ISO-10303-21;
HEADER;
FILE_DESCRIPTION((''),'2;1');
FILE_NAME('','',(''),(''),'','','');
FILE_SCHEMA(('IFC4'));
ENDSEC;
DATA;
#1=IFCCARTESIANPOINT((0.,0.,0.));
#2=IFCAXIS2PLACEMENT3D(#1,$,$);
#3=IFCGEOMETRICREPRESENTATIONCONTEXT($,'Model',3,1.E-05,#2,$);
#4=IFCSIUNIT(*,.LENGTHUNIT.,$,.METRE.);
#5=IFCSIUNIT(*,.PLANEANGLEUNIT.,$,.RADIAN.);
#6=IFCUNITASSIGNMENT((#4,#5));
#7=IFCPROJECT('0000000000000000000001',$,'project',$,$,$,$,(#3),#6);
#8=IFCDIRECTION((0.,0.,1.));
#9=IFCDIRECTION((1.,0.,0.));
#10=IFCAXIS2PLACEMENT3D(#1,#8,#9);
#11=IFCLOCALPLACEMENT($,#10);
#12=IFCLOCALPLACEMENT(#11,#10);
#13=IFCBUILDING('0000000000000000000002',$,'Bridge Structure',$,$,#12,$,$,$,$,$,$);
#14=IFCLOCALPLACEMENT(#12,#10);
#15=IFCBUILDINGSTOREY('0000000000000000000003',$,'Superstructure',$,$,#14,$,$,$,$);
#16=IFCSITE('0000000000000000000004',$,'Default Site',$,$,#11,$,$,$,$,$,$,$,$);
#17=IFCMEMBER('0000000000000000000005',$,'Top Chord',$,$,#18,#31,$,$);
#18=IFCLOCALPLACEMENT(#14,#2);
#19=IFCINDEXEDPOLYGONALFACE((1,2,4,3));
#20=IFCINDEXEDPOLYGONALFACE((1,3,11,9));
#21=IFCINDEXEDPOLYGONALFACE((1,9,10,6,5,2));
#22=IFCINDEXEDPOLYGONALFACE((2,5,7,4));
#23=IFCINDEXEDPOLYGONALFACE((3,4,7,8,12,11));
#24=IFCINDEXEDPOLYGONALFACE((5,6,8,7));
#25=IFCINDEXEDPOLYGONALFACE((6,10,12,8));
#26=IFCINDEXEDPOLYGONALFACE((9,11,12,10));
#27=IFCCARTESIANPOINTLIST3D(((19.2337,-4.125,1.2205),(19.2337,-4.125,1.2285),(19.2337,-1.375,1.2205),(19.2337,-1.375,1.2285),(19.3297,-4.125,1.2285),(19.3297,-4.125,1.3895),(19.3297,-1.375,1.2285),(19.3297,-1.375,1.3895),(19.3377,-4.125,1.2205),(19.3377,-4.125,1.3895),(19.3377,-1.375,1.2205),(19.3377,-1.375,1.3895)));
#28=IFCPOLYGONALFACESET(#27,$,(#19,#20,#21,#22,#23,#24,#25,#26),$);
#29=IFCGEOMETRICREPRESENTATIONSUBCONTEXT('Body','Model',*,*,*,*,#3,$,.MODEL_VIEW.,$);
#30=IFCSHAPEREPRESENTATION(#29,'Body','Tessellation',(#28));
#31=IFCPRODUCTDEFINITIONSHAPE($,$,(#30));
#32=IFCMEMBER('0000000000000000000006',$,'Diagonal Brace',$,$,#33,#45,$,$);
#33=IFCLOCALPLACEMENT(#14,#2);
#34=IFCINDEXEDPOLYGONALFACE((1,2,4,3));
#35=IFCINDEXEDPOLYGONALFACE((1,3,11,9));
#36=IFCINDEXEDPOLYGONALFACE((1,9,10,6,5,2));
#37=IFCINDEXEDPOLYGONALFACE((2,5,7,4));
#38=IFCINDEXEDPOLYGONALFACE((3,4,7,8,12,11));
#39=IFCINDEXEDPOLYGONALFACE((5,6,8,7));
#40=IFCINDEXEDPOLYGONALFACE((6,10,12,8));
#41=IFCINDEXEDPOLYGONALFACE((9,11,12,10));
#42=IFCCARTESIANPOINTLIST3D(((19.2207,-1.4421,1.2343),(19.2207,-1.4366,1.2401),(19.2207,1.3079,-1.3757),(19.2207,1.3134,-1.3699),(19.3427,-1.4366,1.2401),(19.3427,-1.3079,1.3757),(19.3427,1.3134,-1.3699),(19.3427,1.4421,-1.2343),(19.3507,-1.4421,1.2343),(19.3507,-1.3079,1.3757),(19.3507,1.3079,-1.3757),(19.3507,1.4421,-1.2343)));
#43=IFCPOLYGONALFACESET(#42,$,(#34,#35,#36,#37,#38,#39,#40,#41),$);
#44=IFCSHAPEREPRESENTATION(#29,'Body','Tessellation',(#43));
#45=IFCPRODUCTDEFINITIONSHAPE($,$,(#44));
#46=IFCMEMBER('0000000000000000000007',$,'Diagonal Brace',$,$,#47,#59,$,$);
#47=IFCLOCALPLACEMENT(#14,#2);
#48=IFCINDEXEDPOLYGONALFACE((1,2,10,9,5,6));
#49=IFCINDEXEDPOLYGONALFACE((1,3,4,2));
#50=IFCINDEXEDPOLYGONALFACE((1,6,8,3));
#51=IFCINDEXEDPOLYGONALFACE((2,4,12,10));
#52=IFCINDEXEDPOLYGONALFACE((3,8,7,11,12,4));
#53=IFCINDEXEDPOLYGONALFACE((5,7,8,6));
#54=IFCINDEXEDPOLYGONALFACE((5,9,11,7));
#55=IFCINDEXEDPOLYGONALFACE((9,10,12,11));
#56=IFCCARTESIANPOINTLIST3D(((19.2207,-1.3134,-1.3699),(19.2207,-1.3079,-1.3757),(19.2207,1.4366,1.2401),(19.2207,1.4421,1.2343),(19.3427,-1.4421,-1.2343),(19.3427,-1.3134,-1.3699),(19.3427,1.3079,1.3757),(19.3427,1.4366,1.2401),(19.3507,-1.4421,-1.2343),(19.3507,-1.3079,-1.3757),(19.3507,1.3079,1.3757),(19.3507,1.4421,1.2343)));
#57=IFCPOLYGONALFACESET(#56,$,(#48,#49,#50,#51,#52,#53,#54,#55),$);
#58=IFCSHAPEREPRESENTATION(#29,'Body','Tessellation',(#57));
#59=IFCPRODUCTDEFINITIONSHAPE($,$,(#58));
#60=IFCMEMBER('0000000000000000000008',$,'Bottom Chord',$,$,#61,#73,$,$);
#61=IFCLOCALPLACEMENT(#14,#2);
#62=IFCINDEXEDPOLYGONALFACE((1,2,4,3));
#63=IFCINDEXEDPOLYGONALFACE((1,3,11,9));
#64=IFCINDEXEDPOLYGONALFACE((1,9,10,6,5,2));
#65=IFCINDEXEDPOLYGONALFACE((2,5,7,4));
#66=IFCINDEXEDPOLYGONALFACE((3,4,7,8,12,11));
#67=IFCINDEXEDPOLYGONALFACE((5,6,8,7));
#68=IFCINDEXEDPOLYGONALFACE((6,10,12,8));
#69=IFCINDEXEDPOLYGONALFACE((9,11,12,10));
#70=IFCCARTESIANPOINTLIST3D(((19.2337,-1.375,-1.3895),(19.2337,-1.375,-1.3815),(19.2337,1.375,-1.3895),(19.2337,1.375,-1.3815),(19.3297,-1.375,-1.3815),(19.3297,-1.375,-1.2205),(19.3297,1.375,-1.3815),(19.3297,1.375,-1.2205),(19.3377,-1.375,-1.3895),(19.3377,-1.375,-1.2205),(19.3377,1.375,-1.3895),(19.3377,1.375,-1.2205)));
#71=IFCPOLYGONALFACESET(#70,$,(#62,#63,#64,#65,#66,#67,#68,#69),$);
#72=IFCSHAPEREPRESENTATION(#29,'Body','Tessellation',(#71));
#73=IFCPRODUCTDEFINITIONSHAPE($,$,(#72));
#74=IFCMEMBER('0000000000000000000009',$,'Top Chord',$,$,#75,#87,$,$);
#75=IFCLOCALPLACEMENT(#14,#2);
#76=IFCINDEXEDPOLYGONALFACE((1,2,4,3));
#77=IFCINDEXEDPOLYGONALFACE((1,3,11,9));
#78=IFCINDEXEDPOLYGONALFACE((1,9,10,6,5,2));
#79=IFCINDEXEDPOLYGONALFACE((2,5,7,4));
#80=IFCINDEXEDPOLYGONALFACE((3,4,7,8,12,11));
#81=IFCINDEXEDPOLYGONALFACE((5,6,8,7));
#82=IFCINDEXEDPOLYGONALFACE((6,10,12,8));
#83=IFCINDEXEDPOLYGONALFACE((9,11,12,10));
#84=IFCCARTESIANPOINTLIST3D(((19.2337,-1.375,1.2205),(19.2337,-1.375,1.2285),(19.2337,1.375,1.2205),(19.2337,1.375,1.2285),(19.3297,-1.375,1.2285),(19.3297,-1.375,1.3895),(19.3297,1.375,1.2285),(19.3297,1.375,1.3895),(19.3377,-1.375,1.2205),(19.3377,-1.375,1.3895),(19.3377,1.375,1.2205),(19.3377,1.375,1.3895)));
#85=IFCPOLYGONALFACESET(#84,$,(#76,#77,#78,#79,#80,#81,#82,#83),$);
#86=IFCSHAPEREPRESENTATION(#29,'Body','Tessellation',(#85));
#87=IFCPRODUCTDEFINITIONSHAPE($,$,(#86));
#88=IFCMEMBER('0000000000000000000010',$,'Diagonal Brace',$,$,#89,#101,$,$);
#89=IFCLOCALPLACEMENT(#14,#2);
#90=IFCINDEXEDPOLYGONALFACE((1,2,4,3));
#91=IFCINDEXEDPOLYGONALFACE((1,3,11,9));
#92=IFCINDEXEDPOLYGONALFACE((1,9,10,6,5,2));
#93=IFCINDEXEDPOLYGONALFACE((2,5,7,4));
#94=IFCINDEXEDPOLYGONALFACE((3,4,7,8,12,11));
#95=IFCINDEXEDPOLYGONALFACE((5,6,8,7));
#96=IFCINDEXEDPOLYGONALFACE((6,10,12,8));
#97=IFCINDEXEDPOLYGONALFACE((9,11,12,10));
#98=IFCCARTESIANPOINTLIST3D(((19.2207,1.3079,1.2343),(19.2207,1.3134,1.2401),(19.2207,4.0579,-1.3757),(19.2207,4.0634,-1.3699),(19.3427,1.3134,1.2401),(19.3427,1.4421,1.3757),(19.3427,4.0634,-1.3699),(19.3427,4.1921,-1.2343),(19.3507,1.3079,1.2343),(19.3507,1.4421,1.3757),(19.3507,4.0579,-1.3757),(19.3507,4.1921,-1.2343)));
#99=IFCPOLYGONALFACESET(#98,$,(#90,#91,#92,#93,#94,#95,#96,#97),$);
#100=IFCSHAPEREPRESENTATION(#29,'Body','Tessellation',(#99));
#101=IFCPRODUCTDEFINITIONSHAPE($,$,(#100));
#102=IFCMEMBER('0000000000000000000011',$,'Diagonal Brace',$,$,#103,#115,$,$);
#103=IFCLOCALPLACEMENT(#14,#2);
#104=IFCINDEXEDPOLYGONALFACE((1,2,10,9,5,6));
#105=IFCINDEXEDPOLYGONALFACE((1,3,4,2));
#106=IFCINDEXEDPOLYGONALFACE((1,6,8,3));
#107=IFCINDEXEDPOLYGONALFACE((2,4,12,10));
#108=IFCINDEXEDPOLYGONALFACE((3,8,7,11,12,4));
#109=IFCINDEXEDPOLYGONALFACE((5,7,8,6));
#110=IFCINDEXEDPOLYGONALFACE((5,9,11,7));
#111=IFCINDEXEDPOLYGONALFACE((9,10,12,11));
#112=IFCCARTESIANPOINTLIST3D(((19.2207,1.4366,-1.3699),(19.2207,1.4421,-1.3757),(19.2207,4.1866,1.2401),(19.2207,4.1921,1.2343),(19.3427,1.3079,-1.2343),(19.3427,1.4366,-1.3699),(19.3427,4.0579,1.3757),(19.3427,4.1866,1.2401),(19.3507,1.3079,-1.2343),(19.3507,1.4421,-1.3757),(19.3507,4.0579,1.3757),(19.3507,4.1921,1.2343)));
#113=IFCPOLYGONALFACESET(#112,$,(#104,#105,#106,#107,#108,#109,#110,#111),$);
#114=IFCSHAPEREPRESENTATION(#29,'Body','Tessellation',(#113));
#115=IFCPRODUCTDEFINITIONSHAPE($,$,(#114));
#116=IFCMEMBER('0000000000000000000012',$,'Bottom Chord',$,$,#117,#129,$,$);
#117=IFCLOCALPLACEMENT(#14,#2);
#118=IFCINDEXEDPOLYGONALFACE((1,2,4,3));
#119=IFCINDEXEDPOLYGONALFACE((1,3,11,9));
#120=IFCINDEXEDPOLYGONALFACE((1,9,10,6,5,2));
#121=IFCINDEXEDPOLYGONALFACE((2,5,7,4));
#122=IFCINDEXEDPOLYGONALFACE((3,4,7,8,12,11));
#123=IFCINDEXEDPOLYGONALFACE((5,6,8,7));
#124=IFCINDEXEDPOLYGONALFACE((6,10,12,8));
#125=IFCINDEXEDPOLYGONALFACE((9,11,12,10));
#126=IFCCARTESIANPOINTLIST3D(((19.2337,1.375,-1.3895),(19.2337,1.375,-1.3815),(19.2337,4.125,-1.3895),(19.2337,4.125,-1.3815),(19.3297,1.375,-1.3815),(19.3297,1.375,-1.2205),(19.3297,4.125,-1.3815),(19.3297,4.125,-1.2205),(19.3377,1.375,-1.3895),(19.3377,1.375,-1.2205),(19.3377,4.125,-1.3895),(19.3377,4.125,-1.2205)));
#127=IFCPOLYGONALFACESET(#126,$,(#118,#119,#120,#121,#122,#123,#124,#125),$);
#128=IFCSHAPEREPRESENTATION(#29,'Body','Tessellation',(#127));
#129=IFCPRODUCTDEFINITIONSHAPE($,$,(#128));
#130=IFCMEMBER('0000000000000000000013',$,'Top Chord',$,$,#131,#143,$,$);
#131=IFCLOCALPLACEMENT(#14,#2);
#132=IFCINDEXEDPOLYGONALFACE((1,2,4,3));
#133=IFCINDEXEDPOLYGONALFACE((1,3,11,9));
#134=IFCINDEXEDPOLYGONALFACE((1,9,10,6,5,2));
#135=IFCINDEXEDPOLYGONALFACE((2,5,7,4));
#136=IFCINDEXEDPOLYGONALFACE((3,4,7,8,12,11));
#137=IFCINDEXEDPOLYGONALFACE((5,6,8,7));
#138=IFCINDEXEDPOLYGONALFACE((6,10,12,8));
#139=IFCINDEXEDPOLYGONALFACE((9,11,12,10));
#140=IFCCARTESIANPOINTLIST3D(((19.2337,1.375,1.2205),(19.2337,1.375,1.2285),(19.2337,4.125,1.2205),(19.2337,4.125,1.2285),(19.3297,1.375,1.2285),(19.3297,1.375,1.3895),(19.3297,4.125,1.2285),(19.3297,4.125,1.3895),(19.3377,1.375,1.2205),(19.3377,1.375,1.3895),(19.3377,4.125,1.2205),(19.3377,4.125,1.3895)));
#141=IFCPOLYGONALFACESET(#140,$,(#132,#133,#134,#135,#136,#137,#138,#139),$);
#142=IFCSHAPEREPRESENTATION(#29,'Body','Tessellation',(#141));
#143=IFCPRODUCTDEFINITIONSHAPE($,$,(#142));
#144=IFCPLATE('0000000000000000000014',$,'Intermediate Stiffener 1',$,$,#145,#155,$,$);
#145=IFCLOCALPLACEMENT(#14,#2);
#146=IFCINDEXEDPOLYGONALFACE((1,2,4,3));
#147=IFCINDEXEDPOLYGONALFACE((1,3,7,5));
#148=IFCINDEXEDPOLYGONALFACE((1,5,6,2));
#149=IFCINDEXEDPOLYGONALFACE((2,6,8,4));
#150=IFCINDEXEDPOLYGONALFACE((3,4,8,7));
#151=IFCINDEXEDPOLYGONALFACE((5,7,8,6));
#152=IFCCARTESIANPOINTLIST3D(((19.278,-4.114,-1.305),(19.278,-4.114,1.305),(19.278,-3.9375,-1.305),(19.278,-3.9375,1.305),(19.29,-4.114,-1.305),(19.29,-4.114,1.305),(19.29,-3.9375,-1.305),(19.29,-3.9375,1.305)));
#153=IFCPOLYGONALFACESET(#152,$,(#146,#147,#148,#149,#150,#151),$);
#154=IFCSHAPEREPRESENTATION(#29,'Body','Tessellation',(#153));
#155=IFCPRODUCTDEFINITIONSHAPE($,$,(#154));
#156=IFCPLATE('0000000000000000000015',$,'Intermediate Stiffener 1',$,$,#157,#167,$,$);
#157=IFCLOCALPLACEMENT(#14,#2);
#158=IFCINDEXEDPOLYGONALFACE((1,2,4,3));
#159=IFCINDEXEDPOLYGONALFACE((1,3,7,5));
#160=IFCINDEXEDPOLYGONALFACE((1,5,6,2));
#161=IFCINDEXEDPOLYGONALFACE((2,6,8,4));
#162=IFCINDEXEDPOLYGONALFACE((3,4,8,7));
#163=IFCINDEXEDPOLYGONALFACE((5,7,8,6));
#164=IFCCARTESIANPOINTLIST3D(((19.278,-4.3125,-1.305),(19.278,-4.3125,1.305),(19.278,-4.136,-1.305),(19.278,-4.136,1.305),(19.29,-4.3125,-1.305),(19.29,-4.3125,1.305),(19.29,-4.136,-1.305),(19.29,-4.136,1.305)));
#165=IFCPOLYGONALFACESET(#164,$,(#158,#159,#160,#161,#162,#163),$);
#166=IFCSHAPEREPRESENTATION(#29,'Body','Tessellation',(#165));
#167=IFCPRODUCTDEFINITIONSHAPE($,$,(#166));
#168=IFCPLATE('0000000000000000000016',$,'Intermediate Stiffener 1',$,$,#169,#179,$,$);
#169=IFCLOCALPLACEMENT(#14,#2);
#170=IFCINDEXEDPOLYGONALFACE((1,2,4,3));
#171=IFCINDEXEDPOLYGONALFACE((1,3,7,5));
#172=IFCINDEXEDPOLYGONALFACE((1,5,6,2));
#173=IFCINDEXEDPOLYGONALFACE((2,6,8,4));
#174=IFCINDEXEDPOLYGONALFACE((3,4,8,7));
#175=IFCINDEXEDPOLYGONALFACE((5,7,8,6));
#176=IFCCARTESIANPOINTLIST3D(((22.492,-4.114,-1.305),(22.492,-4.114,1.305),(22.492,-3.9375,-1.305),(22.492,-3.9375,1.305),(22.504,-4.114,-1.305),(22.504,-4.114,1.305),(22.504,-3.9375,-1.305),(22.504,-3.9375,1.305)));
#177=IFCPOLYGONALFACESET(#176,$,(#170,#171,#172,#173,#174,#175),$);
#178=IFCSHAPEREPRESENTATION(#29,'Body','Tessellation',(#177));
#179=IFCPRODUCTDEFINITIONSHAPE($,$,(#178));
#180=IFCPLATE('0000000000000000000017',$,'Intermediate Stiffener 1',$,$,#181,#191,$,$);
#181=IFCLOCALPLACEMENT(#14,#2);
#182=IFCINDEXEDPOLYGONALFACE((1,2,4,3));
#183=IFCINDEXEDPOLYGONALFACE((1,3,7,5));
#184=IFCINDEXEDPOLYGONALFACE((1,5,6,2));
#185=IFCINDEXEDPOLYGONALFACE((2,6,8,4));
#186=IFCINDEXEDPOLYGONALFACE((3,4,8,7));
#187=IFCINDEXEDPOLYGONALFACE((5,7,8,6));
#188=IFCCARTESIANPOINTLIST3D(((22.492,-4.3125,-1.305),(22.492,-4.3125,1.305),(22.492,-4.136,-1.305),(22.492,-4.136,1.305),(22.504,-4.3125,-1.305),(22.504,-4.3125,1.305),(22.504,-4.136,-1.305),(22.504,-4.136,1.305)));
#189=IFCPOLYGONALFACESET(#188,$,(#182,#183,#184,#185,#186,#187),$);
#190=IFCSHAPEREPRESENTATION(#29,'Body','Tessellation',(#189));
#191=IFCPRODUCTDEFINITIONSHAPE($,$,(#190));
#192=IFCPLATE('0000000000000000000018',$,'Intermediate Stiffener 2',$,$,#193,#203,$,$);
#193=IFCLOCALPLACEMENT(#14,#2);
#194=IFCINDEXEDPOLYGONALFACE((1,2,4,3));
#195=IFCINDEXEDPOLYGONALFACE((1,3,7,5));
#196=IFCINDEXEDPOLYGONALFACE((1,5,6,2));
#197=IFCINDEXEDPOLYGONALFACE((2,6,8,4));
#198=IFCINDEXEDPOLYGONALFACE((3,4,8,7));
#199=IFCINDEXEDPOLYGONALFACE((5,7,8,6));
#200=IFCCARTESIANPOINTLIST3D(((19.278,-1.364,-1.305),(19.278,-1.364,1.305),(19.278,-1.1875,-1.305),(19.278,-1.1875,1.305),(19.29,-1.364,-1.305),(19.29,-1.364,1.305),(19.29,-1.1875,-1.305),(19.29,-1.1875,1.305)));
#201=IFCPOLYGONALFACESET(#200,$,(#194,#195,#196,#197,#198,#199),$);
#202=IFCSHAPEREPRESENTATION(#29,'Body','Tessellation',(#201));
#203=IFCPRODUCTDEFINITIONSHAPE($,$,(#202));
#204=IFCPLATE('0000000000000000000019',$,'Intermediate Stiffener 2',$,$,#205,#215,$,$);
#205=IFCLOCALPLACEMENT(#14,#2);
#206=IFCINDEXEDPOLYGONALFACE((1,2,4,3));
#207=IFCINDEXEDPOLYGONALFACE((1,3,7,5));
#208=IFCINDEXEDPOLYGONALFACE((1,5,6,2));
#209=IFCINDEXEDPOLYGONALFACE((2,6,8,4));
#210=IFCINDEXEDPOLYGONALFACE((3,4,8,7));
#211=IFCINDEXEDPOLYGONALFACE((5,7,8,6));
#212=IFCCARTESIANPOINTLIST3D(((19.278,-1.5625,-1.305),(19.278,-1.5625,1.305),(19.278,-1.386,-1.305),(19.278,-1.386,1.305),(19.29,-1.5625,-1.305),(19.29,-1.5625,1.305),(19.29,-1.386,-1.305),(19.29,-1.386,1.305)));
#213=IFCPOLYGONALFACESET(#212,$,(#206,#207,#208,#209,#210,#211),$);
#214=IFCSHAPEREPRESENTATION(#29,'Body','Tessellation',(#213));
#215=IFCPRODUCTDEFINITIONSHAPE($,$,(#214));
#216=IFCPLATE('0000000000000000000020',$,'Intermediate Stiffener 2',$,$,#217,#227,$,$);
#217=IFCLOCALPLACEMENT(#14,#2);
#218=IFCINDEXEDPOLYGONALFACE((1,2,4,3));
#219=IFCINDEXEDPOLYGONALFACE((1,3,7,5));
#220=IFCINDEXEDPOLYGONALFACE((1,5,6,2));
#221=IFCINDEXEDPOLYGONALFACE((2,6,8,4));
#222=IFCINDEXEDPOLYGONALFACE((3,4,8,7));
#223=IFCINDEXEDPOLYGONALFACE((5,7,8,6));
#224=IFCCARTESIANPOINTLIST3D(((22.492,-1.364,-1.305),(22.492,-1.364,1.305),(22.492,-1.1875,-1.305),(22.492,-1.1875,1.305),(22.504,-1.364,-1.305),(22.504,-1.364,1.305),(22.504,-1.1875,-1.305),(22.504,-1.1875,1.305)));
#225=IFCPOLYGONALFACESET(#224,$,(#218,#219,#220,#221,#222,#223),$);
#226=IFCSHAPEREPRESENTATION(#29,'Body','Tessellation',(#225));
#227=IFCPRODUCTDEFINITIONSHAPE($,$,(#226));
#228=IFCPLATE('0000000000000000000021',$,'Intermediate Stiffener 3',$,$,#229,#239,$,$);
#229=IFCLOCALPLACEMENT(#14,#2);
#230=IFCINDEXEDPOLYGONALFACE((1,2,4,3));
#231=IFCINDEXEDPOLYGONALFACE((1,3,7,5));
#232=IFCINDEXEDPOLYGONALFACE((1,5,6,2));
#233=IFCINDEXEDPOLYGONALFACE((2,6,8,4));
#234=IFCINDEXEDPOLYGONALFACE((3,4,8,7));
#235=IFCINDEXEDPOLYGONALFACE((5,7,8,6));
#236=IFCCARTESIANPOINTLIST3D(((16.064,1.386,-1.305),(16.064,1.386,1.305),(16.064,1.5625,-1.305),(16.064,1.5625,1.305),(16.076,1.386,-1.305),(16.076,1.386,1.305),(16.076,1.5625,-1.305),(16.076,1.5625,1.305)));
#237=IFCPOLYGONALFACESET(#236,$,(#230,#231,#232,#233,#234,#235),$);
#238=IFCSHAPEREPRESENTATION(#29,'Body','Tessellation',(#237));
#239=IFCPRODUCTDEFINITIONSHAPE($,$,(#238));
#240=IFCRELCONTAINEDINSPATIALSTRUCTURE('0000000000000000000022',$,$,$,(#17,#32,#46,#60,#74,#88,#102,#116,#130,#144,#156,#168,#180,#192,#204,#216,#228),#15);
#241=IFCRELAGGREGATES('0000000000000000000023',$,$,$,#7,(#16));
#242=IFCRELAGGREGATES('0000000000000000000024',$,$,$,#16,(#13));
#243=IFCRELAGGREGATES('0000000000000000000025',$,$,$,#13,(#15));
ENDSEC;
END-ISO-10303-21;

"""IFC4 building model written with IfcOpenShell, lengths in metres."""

from ifc_helpers import new_model, si_unit, frame, origin, origin_with_axes, origin_2d_with_axis, place, context, subcontext, project, spatial, rectangle, l_section, extrude, element, save


model = new_model("IFC4")

# Units and contexts
model_context = context("Model", 3, precision=1e-05, world=origin())
body_context = subcontext(model_context, "Body", "Model", "MODEL_VIEW")
ifc_project = project(units=[si_unit("LENGTHUNIT", "METRE"), si_unit("PLANEANGLEUNIT", "RADIAN")], contexts=[model_context])

# Site, building, storey
site_placement = place(None, origin_with_axes())
site = spatial("IfcSite", under=ifc_project, at=site_placement, Name="Default Site")
building_placement = place(site_placement, origin_with_axes())
building = spatial("IfcBuilding", under=site, at=building_placement, Name="Bridge Structure")
storey_placement = place(building_placement, origin_with_axes())
storey = spatial("IfcBuildingStorey", under=building, at=storey_placement, Name="Superstructure")

# Members
for number, where, z_axis, x_axis, name in (
    (1, (19.2857, -4.125, 1.305), (0.0, 1.0, 0.0), (-1.0, 0.0, 0.0), "Top Chord"),
):
    element("IfcMember", number, at=place(storey_placement, frame(where, z_axis=z_axis, x_axis=x_axis)), inside=storey, Name=name, context=body_context, shape_type="SweptSolid", body=[
        extrude(l_section(Depth=0.169, Width=0.104, Thickness=0.008, at=origin_2d_with_axis()), origin_with_axes(), (0.0, 0.0, 1.0), 2.75),
    ])
for number, where, z_axis, x_axis, name in (
    (2, (19.2857, -1.375, 1.305), (0.0, 0.725329, -0.688403), (-1.0, 0.0, 0.0), "Diagonal Brace"),
    (3, (19.2857, -1.375, -1.305), (0.0, 0.725329, 0.688403), (-1.0, 0.0, 0.0), "Diagonal Brace"),
):
    element("IfcMember", number, at=place(storey_placement, frame(where, z_axis=z_axis, x_axis=x_axis)), inside=storey, Name=name, context=body_context, shape_type="SweptSolid", body=[
        extrude(l_section(Depth=0.195, Width=0.13, Thickness=0.008, at=origin_2d_with_axis()), origin_with_axes(), (0.0, 0.0, 1.0), 3.7914),
    ])
for number, where, z_axis, x_axis, name in (
    (4, (19.2857, -1.375, -1.305), (0.0, 1.0, 0.0), (-1.0, 0.0, 0.0), "Bottom Chord"),
    (5, (19.2857, -1.375, 1.305), (0.0, 1.0, 0.0), (-1.0, 0.0, 0.0), "Top Chord"),
):
    element("IfcMember", number, at=place(storey_placement, frame(where, z_axis=z_axis, x_axis=x_axis)), inside=storey, Name=name, context=body_context, shape_type="SweptSolid", body=[
        extrude(l_section(Depth=0.169, Width=0.104, Thickness=0.008, at=origin_2d_with_axis()), origin_with_axes(), (0.0, 0.0, 1.0), 2.75),
    ])
for number, where, z_axis, x_axis, name in (
    (6, (19.2857, 1.375, 1.305), (0.0, 0.725329, -0.688403), (-1.0, 0.0, 0.0), "Diagonal Brace"),
    (7, (19.2857, 1.375, -1.305), (0.0, 0.725329, 0.688403), (-1.0, 0.0, 0.0), "Diagonal Brace"),
):
    element("IfcMember", number, at=place(storey_placement, frame(where, z_axis=z_axis, x_axis=x_axis)), inside=storey, Name=name, context=body_context, shape_type="SweptSolid", body=[
        extrude(l_section(Depth=0.195, Width=0.13, Thickness=0.008, at=origin_2d_with_axis()), origin_with_axes(), (0.0, 0.0, 1.0), 3.7914),
    ])
for number, where, z_axis, x_axis, name in (
    (8, (19.2857, 1.375, -1.305), (0.0, 1.0, 0.0), (-1.0, 0.0, 0.0), "Bottom Chord"),
    (9, (19.2857, 1.375, 1.305), (0.0, 1.0, 0.0), (-1.0, 0.0, 0.0), "Top Chord"),
):
    element("IfcMember", number, at=place(storey_placement, frame(where, z_axis=z_axis, x_axis=x_axis)), inside=storey, Name=name, context=body_context, shape_type="SweptSolid", body=[
        extrude(l_section(Depth=0.169, Width=0.104, Thickness=0.008, at=origin_2d_with_axis()), origin_with_axes(), (0.0, 0.0, 1.0), 2.75),
    ])

# Plates
for number, where, z_axis, x_axis, name in (
    (10, (19.284, -4.0258, -1.305), (0.0, 0.0, 1.0), (1.0, 0.0, 0.0), "Intermediate Stiffener 1"),
    (11, (19.284, -4.2243, -1.305), (0.0, 0.0, 1.0), (1.0, 0.0, 0.0), "Intermediate Stiffener 1"),
    (12, (22.498, -4.0258, -1.305), (0.0, 0.0, 1.0), (1.0, 0.0, 0.0), "Intermediate Stiffener 1"),
    (13, (22.498, -4.2243, -1.305), (0.0, 0.0, 1.0), (1.0, 0.0, 0.0), "Intermediate Stiffener 1"),
    (14, (19.284, -1.2757, -1.305), (0.0, 0.0, 1.0), (1.0, 0.0, 0.0), "Intermediate Stiffener 2"),
    (15, (19.284, -1.4743, -1.305), (0.0, 0.0, 1.0), (1.0, 0.0, 0.0), "Intermediate Stiffener 2"),
    (16, (22.498, -1.2757, -1.305), (0.0, 0.0, 1.0), (1.0, 0.0, 0.0), "Intermediate Stiffener 2"),
    (17, (16.07, 1.4743, -1.305), (0.0, 0.0, 1.0), (1.0, 0.0, 0.0), "Intermediate Stiffener 3"),
):
    element("IfcPlate", number, at=place(storey_placement, frame(where, z_axis=z_axis, x_axis=x_axis)), inside=storey, Name=name, context=body_context, shape_type="SweptSolid", body=[
        extrude(rectangle(XDim=0.012, YDim=0.1765, at=origin_2d_with_axis()), origin_with_axes(), (0.0, 0.0, 1.0), 2.61),
    ])

save(model, "model.ifc")
